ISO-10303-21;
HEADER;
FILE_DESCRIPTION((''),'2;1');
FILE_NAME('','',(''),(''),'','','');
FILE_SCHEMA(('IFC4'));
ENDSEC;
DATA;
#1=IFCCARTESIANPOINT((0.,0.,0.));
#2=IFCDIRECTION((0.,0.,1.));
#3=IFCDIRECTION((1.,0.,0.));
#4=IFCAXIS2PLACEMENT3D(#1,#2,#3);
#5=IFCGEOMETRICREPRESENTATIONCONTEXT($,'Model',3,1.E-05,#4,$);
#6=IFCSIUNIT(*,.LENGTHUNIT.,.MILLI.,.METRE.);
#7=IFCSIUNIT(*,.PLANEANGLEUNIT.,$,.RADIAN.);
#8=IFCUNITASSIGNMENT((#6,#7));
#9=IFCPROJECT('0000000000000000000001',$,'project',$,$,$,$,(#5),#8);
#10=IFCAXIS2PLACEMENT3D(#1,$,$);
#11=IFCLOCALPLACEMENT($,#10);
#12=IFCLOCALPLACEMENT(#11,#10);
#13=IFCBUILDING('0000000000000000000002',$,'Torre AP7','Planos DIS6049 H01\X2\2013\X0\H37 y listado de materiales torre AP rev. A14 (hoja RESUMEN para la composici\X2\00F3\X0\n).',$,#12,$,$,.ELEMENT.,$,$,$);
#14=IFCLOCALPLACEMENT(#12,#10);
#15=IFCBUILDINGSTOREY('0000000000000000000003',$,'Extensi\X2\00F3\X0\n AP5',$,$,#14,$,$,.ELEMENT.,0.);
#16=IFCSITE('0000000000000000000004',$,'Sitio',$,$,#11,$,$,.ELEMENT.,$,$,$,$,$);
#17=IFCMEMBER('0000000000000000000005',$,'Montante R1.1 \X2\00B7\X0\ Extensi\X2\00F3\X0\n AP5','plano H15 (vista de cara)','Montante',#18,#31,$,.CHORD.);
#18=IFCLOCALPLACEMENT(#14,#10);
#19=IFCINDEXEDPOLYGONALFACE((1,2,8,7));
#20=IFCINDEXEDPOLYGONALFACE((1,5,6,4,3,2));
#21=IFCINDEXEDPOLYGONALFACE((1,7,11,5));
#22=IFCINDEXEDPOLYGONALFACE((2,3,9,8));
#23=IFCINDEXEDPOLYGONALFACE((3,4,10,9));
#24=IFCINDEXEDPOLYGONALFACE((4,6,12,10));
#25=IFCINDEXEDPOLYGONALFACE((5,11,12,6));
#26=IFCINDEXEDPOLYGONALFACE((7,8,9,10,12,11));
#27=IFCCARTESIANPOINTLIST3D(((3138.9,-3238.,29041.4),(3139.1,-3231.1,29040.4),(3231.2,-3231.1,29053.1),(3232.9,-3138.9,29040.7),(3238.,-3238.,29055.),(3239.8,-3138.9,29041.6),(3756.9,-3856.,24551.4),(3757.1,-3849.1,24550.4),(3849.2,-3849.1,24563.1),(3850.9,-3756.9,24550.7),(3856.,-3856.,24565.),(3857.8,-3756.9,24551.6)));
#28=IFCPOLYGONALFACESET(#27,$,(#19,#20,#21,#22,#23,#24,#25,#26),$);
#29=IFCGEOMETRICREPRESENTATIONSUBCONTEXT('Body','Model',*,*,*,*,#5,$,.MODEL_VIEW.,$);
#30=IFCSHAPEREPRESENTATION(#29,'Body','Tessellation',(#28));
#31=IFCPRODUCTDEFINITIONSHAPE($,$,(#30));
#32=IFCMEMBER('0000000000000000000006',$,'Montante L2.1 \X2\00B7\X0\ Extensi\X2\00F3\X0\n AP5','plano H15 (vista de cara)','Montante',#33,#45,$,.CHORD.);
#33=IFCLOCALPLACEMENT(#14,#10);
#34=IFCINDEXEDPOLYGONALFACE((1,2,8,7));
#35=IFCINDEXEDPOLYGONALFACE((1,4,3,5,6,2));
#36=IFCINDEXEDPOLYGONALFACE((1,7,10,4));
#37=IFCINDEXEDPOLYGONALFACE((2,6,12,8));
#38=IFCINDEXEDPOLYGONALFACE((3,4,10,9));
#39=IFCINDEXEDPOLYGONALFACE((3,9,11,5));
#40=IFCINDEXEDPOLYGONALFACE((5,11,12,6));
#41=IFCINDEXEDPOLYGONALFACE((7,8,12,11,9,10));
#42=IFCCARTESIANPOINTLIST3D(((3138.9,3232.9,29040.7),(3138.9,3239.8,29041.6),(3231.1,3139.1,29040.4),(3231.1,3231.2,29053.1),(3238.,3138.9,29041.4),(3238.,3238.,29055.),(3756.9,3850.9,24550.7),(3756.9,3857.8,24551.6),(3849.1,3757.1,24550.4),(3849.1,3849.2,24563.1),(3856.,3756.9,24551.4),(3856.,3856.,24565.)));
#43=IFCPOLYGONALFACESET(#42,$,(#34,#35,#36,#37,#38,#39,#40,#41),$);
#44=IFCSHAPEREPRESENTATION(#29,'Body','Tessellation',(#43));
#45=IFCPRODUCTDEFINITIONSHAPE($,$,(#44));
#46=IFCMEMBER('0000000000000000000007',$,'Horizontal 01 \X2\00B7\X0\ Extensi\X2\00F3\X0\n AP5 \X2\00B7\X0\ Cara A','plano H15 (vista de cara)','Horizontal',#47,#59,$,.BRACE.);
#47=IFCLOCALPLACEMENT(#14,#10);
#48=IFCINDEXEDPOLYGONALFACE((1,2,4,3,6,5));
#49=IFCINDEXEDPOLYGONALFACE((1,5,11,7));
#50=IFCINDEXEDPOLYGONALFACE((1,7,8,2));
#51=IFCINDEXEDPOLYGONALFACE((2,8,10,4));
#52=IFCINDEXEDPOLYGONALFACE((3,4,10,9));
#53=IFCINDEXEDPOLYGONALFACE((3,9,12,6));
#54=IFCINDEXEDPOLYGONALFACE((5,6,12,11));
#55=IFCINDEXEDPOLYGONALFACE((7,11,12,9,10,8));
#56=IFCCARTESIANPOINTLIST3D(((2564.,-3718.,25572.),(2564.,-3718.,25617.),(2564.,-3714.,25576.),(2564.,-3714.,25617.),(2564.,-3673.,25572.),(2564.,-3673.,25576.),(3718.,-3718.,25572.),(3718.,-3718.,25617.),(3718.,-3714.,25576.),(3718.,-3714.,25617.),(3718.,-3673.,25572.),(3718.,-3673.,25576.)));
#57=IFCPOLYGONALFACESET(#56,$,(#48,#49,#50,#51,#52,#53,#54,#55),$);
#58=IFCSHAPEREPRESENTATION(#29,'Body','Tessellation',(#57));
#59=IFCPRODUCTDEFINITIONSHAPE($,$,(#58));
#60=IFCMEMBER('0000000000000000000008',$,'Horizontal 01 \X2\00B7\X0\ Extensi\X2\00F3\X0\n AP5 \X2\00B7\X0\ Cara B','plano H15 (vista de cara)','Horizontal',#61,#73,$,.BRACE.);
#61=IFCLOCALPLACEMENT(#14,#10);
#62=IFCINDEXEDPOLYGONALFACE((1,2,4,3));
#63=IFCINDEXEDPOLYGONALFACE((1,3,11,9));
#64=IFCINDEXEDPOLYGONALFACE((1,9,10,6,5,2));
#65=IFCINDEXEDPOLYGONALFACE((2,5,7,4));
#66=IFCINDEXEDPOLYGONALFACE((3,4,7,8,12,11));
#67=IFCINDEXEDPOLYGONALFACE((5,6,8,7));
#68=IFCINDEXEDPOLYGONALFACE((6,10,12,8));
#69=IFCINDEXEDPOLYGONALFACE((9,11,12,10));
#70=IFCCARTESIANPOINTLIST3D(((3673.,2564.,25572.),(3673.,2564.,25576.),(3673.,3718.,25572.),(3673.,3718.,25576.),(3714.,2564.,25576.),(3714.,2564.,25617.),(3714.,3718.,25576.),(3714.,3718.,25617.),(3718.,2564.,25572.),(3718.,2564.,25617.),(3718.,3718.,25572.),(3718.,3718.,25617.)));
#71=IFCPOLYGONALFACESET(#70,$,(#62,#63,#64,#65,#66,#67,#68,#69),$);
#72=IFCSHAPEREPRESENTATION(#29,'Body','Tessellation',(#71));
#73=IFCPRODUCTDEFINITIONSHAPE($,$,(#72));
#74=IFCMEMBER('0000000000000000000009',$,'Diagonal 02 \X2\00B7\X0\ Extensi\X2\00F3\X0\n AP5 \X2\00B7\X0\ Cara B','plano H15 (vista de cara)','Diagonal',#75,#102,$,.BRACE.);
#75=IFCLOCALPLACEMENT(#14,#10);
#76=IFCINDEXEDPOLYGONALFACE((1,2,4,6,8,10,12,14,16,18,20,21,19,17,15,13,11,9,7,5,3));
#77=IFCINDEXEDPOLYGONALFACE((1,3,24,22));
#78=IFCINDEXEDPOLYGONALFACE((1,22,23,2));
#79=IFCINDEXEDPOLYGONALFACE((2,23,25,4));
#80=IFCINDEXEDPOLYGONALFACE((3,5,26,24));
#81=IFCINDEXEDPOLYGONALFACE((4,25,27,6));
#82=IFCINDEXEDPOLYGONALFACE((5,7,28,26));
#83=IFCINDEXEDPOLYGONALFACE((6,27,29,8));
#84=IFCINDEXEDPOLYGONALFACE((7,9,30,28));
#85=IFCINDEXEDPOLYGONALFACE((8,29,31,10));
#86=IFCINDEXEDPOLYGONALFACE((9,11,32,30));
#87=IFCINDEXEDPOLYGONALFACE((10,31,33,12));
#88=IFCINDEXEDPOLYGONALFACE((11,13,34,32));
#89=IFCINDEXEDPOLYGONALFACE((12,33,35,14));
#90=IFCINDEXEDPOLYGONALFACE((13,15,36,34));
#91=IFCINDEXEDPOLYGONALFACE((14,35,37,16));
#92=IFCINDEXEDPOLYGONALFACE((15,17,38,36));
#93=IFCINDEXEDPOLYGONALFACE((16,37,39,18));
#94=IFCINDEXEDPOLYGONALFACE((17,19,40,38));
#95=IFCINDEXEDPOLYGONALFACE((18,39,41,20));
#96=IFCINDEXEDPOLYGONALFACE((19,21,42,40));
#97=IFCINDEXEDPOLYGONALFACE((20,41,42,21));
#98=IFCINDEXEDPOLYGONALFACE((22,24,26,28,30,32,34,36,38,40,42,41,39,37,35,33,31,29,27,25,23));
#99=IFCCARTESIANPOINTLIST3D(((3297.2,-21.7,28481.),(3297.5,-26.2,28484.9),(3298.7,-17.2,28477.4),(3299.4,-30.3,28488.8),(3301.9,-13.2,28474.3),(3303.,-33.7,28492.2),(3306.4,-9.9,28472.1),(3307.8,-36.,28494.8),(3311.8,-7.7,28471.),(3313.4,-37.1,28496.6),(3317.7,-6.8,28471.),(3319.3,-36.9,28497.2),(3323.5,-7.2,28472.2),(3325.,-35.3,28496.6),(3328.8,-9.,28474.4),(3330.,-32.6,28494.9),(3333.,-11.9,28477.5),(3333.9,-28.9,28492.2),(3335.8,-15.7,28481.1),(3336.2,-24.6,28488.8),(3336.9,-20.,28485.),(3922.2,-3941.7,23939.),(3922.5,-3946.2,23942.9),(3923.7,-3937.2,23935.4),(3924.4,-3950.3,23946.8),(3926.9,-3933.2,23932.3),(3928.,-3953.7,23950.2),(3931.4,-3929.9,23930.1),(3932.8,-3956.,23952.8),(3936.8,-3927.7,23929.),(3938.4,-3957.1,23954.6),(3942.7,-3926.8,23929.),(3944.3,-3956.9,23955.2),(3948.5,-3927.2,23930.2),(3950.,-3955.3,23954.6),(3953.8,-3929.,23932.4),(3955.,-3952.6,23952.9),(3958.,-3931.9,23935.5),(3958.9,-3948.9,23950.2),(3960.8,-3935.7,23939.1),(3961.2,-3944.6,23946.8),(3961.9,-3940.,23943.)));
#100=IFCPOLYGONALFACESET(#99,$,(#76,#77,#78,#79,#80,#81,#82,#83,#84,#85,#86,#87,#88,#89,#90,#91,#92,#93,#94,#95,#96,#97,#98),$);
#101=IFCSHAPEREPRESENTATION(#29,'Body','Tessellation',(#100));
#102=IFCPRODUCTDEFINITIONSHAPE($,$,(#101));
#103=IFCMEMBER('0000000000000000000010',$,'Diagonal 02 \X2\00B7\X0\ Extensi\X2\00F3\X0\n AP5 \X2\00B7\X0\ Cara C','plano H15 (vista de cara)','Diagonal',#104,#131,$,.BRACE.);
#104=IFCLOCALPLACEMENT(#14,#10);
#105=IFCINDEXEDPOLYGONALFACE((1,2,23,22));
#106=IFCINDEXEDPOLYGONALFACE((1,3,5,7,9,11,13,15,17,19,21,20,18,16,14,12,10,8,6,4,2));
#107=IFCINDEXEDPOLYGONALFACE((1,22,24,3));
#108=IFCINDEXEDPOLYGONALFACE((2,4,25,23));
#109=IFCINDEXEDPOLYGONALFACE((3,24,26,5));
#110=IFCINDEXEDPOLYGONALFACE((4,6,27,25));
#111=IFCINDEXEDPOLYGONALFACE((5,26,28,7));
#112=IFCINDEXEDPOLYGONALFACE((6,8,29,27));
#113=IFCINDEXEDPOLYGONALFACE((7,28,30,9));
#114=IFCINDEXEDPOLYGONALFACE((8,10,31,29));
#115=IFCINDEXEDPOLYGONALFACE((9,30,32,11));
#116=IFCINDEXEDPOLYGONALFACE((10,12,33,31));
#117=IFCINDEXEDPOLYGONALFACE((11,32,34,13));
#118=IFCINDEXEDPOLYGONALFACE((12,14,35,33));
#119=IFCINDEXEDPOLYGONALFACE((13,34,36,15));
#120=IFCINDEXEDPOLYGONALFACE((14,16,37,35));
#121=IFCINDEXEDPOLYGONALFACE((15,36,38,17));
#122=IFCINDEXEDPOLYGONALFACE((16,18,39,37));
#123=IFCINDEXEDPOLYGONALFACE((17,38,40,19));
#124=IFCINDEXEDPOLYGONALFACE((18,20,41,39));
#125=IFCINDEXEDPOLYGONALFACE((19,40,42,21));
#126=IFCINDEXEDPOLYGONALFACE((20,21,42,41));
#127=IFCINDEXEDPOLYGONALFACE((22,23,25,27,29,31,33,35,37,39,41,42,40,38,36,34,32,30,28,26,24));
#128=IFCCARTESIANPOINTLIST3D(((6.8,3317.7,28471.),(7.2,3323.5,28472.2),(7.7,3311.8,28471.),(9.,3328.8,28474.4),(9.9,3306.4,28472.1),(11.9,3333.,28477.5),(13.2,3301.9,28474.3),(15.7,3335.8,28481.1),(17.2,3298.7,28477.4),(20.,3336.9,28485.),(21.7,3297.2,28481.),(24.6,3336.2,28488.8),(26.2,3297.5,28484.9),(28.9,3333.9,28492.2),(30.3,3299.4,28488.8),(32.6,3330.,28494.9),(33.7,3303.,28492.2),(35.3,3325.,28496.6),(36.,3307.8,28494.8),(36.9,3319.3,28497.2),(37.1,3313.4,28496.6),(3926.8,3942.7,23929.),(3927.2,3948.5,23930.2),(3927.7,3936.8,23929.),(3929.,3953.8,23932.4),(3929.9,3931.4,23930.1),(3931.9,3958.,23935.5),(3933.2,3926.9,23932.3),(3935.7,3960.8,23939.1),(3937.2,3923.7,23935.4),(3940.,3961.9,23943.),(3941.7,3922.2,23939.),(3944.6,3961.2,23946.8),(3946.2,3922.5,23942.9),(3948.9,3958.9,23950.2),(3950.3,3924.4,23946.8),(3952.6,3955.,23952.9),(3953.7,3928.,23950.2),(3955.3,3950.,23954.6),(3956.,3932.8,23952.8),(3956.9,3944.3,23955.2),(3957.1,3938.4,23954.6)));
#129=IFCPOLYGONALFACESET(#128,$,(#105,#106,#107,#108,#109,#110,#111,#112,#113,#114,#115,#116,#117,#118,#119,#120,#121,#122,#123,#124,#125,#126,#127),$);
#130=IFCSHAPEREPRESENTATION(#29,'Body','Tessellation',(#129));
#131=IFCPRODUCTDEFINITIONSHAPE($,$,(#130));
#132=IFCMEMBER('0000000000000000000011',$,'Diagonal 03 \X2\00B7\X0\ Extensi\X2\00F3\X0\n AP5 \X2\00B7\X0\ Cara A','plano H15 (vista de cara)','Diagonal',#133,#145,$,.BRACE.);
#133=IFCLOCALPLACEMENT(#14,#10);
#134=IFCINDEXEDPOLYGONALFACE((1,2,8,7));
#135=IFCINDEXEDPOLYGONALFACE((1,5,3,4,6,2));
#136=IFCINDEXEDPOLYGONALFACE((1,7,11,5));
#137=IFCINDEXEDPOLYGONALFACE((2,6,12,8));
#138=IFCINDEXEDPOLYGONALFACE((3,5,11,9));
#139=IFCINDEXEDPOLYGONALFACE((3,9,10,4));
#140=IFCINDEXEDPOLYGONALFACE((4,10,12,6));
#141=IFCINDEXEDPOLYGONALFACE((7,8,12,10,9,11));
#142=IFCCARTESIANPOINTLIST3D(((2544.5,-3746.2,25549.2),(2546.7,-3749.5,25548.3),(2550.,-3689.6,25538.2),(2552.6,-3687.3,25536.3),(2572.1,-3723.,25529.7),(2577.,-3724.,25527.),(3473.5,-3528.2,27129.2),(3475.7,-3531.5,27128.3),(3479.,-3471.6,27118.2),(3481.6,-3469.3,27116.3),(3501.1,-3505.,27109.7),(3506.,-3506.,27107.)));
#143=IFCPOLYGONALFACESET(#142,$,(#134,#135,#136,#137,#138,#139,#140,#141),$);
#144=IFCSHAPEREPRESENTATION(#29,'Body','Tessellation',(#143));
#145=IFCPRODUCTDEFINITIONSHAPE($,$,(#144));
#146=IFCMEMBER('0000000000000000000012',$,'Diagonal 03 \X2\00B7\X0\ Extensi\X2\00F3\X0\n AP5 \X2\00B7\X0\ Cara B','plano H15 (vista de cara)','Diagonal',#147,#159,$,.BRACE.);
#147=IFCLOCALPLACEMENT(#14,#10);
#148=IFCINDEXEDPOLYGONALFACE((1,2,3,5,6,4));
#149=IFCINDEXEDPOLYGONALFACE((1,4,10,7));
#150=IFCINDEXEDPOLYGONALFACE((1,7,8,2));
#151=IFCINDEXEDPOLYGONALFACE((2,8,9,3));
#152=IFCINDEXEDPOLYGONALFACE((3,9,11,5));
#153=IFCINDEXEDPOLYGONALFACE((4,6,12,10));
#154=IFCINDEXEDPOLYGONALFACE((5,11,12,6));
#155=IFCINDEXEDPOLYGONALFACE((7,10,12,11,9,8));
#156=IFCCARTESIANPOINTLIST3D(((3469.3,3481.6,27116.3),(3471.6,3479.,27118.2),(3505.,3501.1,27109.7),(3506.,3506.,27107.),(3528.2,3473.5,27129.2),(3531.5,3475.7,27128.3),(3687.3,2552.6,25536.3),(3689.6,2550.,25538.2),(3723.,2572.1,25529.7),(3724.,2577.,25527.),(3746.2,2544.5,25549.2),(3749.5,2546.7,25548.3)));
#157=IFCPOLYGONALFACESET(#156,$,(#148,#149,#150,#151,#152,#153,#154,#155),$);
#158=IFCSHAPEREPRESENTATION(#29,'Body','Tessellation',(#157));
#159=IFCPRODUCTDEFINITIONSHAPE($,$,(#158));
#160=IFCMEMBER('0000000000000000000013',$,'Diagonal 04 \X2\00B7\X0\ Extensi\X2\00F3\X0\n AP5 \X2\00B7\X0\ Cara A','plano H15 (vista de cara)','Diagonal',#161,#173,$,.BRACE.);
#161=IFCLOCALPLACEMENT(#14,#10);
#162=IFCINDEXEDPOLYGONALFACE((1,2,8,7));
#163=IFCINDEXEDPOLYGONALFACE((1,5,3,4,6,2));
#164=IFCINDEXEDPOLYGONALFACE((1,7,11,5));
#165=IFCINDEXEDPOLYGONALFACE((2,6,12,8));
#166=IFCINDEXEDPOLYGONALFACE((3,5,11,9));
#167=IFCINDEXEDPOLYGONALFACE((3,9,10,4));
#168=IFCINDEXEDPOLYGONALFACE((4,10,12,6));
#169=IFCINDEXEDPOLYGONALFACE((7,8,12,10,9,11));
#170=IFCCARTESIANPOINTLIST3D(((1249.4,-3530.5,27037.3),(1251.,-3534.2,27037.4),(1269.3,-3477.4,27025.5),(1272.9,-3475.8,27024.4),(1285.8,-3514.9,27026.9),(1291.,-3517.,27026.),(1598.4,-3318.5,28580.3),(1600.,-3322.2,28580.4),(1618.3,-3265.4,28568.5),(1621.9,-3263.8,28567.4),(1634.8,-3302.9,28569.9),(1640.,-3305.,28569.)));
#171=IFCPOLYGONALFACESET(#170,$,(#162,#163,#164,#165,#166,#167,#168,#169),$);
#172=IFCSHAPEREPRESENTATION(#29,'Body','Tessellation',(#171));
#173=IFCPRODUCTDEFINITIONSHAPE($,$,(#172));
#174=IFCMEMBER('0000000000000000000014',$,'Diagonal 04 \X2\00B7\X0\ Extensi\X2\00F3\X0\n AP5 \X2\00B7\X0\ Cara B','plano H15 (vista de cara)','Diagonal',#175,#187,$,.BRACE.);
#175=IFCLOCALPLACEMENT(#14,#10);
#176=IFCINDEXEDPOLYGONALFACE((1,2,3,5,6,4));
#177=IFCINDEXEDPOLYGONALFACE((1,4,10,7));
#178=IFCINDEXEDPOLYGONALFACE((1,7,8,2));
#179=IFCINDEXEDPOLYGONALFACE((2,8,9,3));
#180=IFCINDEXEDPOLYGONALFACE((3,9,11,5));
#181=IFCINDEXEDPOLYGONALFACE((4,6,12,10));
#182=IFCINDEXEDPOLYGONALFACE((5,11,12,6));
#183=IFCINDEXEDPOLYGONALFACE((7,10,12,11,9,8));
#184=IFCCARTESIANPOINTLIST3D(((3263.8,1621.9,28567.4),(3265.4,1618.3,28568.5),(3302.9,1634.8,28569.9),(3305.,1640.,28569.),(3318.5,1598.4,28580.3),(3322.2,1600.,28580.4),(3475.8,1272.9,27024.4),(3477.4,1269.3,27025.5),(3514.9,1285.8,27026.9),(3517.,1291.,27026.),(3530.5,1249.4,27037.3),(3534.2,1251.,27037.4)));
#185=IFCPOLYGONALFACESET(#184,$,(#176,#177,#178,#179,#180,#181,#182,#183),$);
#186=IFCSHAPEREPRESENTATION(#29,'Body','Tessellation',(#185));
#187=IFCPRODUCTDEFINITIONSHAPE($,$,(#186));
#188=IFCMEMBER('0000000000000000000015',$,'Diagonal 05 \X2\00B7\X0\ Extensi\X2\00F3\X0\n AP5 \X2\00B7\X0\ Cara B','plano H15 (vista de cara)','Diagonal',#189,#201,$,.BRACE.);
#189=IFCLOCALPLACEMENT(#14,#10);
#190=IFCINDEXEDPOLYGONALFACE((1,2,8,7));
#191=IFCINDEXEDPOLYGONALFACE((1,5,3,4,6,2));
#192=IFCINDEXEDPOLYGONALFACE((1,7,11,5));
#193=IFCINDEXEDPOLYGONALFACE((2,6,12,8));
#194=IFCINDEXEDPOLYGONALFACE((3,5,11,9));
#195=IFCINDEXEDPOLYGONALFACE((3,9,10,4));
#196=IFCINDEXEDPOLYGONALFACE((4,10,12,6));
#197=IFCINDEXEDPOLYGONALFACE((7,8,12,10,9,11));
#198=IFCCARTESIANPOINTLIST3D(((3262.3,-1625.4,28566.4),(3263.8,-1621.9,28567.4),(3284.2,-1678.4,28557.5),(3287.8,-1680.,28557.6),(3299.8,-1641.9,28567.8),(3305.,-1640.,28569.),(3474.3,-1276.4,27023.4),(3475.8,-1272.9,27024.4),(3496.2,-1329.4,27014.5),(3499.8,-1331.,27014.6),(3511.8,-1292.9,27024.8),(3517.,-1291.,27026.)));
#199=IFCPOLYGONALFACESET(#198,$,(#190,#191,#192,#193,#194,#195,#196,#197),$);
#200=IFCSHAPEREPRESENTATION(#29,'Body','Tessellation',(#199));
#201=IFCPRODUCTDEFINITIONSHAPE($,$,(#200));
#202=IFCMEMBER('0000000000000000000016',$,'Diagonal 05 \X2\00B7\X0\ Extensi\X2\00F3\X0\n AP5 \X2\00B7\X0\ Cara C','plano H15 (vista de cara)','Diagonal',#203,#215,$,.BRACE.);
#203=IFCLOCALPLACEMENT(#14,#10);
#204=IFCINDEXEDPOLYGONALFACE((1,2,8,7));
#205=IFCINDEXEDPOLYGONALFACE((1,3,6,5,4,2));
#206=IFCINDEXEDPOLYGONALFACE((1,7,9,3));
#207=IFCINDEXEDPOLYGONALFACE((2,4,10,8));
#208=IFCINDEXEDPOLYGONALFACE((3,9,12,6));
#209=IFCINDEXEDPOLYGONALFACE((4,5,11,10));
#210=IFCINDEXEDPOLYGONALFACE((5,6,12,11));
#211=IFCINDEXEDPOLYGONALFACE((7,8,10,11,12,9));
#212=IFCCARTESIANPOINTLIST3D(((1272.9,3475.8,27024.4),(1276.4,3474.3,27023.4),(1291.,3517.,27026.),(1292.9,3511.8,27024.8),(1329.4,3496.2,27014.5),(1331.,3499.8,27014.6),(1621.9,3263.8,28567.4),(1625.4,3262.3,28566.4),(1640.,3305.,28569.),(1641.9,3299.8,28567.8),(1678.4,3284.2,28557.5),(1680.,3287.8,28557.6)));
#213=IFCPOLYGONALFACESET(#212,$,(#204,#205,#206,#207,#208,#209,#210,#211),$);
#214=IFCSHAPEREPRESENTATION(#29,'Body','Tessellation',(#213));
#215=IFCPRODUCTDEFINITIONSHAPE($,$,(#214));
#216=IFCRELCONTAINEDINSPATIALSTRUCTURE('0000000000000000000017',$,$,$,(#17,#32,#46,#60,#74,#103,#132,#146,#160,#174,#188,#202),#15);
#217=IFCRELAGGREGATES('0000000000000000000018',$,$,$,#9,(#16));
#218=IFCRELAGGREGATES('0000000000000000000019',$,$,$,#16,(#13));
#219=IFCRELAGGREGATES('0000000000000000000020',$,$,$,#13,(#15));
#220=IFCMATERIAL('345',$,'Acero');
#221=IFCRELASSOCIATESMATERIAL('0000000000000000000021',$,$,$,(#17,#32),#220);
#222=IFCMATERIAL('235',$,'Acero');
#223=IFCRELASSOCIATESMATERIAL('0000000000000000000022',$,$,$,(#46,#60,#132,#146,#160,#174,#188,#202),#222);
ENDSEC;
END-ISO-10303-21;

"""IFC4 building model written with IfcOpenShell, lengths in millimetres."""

from ifc_helpers import new_model, si_unit, frame, frame_2d, origin, origin_with_axes, place, context, subcontext, project, spatial, circle, l_section, extrude, material, element, save


model = new_model("IFC4")

# Units and contexts
model_context = context("Model", 3, precision=1e-05, world=origin_with_axes())
body_context = subcontext(model_context, "Body", "Model", "MODEL_VIEW")
ifc_project = project(units=[si_unit("LENGTHUNIT", "METRE", prefix="MILLI"), si_unit("PLANEANGLEUNIT", "RADIAN")], contexts=[model_context])

# Site, building, storey
site_placement = place(None, origin())
site = spatial("IfcSite", under=ifc_project, at=site_placement, Name="Sitio", CompositionType="ELEMENT")
building_placement = place(site_placement, origin())
building = spatial("IfcBuilding", under=site, at=building_placement, Name="Torre AP7", Description="Planos DIS6049 H01–H37 y listado de materiales torre AP rev. A14 (hoja RESUMEN para la composición).", CompositionType="ELEMENT")
storey_placement = place(building_placement, origin())
storey = spatial("IfcBuildingStorey", under=building, at=storey_placement, Name="Extensión AP5", CompositionType="ELEMENT", Elevation=0.0)

# Members
ifc_material_1 = material(Name="345", Category="Acero")
for number, where, z_axis, x_axis, name in (
    (1, (3856.0, -3856.0, 24565.0), (-0.135104, 0.135104, 0.981577), (0.018422, 0.990831, -0.133842), "Montante R1.1 · Extensión AP5"),
    (2, (3856.0, 3856.0, 24565.0), (-0.135104, -0.135104, 0.981577), (-0.990831, 0.018422, -0.133842), "Montante L2.1 · Extensión AP5"),
):
    element("IfcMember", number, at=place(storey_placement, frame(where, z_axis=z_axis, x_axis=x_axis)), inside=storey, material=ifc_material_1, Name=name, Description="plano H15 (vista de cara)", ObjectType="Montante", PredefinedType="CHORD", context=body_context, shape_type="SweptSolid", body=[
        extrude(l_section(Depth=100.0, Width=100.0, Thickness=7.0, at=frame_2d((50.0, 50.0))), None, (0.0, 0.0, 1.0), 4574.3),
    ])
ifc_material_2 = material(Name="235", Category="Acero")
for number, where, z_axis, x_axis, name in (
    (3, (2564.0, -3718.0, 25572.0), (1.0, 0.0, 0.0), (0.0, 1.0, 0.0), "Horizontal 01 · Extensión AP5 · Cara A"),
    (4, (3718.0, 2564.0, 25572.0), (0.0, 1.0, 0.0), (-1.0, 0.0, 0.0), "Horizontal 01 · Extensión AP5 · Cara B"),
):
    element("IfcMember", number, at=place(storey_placement, frame(where, z_axis=z_axis, x_axis=x_axis)), inside=storey, material=ifc_material_2, Name=name, Description="plano H15 (vista de cara)", ObjectType="Horizontal", PredefinedType="BRACE", context=body_context, shape_type="SweptSolid", body=[
        extrude(l_section(Depth=45.0, Width=45.0, Thickness=4.0, at=frame_2d((22.5, 22.5))), None, (0.0, 0.0, 1.0), 1154.0),
    ])
for number, where, z_axis, x_axis, name in (
    (5, (3942.0, -3942.0, 23942.0), (-0.103612, 0.649852, 0.752966), (-0.913165, 0.237889, -0.330967), "Diagonal 02 · Extensión AP5 · Cara B"),
    (6, (3942.0, 3942.0, 23942.0), (-0.649852, -0.103612, 0.752966), (-0.237889, -0.913165, -0.330967), "Diagonal 02 · Extensión AP5 · Cara C"),
):
    element("IfcMember", number, at=place(storey_placement, frame(where, z_axis=z_axis, x_axis=x_axis)), inside=storey, Name=name, Description="plano H15 (vista de cara)", ObjectType="Diagonal", PredefinedType="BRACE", context=body_context, shape_type="SweptSolid", body=[
        extrude(circle(Radius=20.0), None, (0.0, 0.0, 1.0), 6032.1),
    ])
for number, where, z_axis, x_axis, name in (
    (7, (2577.0, -3724.0, 25527.0), (0.503306, 0.118106, 0.855999), (-0.541181, 0.815359, 0.205702), "Diagonal 03 · Extensión AP5 · Cara A"),
    (8, (3724.0, 2577.0, 25527.0), (-0.118106, 0.503306, 0.855999), (-0.815359, -0.541181, 0.205702), "Diagonal 03 · Extensión AP5 · Cara B"),
):
    element("IfcMember", number, at=place(storey_placement, frame(where, z_axis=z_axis, x_axis=x_axis)), inside=storey, material=ifc_material_2, Name=name, Description="plano H15 (vista de cara)", ObjectType="Diagonal", PredefinedType="BRACE", context=body_context, shape_type="SweptSolid", body=[
        extrude(l_section(Depth=45.0, Width=45.0, Thickness=4.0, at=frame_2d((22.5, 22.5))), None, (0.0, 0.0, 1.0), 1845.8),
    ])
for number, where, z_axis, x_axis, name in (
    (9, (1291.0, -3517.0, 27026.0), (0.218655, 0.132822, 0.96672), (-0.402816, 0.914628, -0.034555), "Diagonal 04 · Extensión AP5 · Cara A"),
    (10, (3517.0, 1291.0, 27026.0), (-0.132822, 0.218655, 0.96672), (-0.914628, -0.402816, -0.034555), "Diagonal 04 · Extensión AP5 · Cara B"),
    (11, (3517.0, -1291.0, 27026.0), (-0.132822, -0.218655, 0.96672), (-0.914628, 0.402816, -0.034555), "Diagonal 05 · Extensión AP5 · Cara B"),
    (12, (1291.0, 3517.0, 27026.0), (0.218655, -0.132822, 0.96672), (-0.402816, -0.914628, -0.034555), "Diagonal 05 · Extensión AP5 · Cara C"),
):
    element("IfcMember", number, at=place(storey_placement, frame(where, z_axis=z_axis, x_axis=x_axis)), inside=storey, material=ifc_material_2, Name=name, Description="plano H15 (vista de cara)", ObjectType="Diagonal", PredefinedType="BRACE", context=body_context, shape_type="SweptSolid", body=[
        extrude(l_section(Depth=45.0, Width=45.0, Thickness=4.0, at=frame_2d((22.5, 22.5))), None, (0.0, 0.0, 1.0), 1596.1),
    ])

save(model, "model.ifc")
